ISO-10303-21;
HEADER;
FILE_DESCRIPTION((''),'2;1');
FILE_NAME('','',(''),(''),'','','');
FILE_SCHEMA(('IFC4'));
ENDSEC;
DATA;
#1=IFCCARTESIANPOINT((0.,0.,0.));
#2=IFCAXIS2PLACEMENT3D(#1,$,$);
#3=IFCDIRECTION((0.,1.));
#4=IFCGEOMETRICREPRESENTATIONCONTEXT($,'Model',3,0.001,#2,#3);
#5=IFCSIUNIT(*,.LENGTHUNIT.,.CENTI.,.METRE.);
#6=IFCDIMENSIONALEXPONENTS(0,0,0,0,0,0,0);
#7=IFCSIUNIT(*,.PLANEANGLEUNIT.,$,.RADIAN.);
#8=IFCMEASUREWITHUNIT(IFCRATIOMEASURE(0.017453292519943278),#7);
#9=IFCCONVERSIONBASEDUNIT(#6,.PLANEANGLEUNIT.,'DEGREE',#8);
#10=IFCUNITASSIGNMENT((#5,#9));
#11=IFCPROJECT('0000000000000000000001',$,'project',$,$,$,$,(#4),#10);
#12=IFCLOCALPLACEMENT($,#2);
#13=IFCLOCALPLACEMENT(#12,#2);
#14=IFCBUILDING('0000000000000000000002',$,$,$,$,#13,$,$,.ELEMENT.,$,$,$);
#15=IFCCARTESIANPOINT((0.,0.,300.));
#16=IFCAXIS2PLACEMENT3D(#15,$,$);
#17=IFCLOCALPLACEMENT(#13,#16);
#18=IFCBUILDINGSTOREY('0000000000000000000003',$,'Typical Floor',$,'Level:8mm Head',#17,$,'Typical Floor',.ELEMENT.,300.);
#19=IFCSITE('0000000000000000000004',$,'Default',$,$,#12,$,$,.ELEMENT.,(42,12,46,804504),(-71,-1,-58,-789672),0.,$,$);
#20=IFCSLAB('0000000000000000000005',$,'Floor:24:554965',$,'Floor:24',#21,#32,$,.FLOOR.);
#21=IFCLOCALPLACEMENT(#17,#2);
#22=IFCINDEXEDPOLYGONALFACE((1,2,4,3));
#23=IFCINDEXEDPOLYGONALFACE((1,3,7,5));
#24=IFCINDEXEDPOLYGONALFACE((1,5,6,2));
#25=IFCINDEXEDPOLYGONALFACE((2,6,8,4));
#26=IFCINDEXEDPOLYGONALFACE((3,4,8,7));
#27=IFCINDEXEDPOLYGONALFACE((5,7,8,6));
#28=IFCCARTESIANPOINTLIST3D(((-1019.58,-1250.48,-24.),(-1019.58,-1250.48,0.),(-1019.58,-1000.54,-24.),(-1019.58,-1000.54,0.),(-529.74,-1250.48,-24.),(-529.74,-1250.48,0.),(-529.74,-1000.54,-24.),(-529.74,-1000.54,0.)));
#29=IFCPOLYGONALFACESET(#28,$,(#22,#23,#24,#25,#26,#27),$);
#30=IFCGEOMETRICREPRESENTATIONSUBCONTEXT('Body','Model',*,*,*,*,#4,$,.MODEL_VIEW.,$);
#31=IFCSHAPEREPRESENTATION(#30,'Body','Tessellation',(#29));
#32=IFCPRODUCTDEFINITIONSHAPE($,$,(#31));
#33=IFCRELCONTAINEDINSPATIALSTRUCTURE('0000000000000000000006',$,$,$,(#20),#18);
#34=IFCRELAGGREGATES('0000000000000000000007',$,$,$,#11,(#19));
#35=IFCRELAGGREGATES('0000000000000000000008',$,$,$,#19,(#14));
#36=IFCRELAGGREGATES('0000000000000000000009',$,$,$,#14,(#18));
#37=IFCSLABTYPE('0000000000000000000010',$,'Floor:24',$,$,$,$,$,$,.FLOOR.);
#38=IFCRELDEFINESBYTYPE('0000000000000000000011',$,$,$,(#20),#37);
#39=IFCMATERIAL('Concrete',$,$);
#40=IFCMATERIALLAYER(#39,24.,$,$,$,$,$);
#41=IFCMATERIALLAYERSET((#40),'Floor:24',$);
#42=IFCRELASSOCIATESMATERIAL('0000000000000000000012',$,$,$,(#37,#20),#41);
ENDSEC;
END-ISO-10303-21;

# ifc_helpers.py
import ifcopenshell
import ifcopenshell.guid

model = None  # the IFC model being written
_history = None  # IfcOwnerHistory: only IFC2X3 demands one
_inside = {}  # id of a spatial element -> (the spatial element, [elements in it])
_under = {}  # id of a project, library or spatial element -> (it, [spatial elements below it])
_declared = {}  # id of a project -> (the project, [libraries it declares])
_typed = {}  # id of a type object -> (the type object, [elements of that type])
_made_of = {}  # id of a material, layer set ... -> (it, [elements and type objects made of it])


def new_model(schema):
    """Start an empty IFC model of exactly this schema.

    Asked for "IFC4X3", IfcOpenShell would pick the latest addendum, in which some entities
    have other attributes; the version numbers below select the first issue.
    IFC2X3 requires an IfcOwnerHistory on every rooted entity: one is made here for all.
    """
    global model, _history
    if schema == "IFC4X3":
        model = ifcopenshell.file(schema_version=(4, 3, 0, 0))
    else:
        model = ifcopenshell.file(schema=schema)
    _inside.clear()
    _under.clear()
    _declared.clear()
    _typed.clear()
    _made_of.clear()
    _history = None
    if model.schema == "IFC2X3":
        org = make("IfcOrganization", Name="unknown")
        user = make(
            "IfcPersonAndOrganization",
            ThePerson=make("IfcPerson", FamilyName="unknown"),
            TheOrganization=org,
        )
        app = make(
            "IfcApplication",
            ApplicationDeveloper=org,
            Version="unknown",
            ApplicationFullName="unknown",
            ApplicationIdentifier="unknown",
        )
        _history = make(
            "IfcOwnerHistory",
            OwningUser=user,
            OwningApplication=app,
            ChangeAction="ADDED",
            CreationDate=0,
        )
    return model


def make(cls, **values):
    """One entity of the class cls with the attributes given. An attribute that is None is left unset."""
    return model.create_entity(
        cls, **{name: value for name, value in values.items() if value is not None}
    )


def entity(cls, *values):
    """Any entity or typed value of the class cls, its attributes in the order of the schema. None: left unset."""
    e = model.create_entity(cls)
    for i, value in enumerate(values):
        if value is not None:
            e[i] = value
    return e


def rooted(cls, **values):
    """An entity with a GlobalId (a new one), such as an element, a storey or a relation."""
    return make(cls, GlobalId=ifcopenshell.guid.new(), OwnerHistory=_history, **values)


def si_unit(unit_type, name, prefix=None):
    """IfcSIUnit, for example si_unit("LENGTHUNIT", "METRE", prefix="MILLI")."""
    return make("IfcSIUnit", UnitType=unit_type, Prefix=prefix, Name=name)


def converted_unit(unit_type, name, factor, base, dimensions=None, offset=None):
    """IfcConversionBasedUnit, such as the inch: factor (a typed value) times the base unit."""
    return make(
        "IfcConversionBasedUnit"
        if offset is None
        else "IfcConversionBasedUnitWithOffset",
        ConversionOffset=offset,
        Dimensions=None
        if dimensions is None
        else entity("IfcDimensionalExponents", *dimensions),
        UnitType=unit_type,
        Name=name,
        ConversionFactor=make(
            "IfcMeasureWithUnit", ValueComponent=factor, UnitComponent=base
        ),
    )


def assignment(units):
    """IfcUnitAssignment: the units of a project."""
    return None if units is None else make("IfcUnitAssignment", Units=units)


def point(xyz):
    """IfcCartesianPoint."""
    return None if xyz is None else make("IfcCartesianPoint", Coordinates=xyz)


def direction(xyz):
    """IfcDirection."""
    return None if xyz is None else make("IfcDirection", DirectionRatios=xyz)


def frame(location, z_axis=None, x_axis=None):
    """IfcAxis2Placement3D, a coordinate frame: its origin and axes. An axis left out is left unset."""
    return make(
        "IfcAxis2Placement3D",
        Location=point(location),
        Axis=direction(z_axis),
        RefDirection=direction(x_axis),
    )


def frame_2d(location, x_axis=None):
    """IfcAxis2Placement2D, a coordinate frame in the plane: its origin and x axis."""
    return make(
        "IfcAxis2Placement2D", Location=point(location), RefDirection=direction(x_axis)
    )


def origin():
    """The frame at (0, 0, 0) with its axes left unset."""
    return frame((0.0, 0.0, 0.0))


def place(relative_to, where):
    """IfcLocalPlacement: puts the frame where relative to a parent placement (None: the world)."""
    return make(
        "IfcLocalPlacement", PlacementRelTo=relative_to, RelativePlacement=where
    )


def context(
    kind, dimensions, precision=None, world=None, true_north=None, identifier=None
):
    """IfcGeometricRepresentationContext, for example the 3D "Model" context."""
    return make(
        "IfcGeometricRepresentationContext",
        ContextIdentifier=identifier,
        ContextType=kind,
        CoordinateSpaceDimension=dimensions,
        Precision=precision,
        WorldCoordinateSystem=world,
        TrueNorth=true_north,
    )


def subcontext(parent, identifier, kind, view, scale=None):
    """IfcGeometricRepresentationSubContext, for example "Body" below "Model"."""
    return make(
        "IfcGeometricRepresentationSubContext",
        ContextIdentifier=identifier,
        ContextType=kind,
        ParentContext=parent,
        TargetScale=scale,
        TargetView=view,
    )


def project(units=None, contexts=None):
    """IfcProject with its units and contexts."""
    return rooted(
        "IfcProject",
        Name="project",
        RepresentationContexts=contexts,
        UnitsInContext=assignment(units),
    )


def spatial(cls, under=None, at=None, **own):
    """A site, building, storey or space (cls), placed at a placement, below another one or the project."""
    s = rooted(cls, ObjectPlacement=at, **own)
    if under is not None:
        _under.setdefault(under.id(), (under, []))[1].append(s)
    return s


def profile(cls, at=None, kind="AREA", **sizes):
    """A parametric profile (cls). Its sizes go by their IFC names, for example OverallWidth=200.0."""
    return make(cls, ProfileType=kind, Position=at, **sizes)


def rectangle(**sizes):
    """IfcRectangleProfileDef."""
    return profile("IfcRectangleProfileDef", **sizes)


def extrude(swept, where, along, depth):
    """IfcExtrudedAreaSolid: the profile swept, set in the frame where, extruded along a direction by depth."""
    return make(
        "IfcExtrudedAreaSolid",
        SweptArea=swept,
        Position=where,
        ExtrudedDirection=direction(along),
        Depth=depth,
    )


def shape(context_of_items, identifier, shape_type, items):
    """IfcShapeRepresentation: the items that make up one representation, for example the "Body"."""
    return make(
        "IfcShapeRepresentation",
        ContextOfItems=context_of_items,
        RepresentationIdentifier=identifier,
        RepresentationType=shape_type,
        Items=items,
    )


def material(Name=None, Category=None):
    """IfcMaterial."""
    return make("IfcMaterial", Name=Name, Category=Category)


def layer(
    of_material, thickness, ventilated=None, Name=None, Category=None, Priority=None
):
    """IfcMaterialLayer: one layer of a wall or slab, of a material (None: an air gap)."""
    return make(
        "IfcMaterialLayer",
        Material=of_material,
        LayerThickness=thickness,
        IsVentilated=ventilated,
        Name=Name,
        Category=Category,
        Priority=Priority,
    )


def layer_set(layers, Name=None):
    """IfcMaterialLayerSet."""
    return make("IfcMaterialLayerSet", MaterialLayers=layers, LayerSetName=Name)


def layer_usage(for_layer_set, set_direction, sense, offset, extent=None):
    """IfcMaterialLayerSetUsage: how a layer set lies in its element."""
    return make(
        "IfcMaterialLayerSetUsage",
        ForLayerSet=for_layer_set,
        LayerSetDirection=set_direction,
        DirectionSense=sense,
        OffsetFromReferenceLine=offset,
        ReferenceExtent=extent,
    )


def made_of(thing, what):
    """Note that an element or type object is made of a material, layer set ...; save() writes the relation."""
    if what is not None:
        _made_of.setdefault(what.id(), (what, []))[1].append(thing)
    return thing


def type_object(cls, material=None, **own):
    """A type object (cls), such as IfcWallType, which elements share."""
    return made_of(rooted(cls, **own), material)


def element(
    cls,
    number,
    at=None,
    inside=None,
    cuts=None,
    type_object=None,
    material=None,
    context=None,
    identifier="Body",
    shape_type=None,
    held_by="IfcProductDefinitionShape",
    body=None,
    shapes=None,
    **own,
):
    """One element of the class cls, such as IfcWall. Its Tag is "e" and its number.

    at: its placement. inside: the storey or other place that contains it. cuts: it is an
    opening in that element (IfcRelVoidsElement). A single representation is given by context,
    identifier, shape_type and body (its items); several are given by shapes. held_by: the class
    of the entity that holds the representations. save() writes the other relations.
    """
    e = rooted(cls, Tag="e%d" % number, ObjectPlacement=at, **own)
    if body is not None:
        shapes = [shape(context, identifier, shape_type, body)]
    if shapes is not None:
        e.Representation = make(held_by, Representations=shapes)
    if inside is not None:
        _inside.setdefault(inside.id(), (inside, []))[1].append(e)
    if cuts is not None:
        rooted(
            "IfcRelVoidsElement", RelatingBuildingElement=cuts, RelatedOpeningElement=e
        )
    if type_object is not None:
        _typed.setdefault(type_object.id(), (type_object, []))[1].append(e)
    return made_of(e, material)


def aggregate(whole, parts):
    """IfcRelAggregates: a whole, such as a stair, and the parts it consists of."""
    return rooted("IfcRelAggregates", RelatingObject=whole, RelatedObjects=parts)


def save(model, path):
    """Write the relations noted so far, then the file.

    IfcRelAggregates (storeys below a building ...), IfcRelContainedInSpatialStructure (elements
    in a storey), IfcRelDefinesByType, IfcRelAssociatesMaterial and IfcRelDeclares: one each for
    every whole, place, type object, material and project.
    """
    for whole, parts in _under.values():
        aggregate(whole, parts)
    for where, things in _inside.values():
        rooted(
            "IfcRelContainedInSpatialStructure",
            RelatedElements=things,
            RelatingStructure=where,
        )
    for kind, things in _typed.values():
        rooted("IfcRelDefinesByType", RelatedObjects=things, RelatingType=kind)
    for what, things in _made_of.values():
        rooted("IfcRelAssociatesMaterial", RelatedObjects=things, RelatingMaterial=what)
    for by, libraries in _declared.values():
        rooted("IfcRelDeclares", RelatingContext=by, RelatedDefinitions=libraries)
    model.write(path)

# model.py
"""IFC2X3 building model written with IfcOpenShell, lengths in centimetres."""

from ifc_helpers import new_model, entity, si_unit, converted_unit, direction, frame, frame_2d, origin, place, context, subcontext, project, spatial, rectangle, extrude, material, layer, layer_set, layer_usage, type_object, element, save


model = new_model("IFC2X3")

# Units and contexts
model_context = context("Model", 3, precision=0.001, world=origin(), true_north=direction((0.0, 1.0)))
body_context = subcontext(model_context, "Body", "Model", "MODEL_VIEW")
ifc_project = project(units=[si_unit("LENGTHUNIT", "METRE", prefix="CENTI"), converted_unit("PLANEANGLEUNIT", "DEGREE", entity("IfcRatioMeasure", 0.017453292519943278), si_unit("PLANEANGLEUNIT", "RADIAN"), dimensions=[0, 0, 0, 0, 0, 0, 0])], contexts=[model_context])

# Site, building, storey
site_placement = place(None, origin())
site = spatial("IfcSite", under=ifc_project, at=site_placement, Name="Default", CompositionType="ELEMENT", RefLatitude=(42, 12, 46, 804504), RefLongitude=(-71, -1, -58, -789672), RefElevation=0.0)
building_placement = place(site_placement, origin())
building = spatial("IfcBuilding", under=site, at=building_placement, CompositionType="ELEMENT")
storey_placement = place(building_placement, frame((0.0, 0.0, 300.0)))
storey = spatial("IfcBuildingStorey", under=building, at=storey_placement, Name="Typical Floor", ObjectType="Level:8mm Head", LongName="Typical Floor", CompositionType="ELEMENT", Elevation=300.0)

# Shared definitions
ifc_material = material(Name="Concrete")

# Slab
ifc_layer = layer(ifc_material, 24.0)
ifc_layer_set = layer_set([ifc_layer], Name="Floor:24")
ifc_layer_usage_1 = layer_usage(ifc_layer_set, "AXIS3", "POSITIVE", 0.0)
slab_type_1 = type_object("IfcSlabType", Name="Floor:24", PredefinedType="FLOOR", material=ifc_layer_set)
slab_1_placement = place(storey_placement, origin())
element("IfcSlab", 1, at=slab_1_placement, inside=storey, type_object=slab_type_1, material=ifc_layer_usage_1, Name="Floor:24:554965", ObjectType="Floor:24", PredefinedType="FLOOR", context=body_context, shape_type="SweptSolid", body=[
    extrude(rectangle(XDim=249.95, YDim=489.84, at=frame_2d((0.0, 0.0), x_axis=(1.0, 0.0))), frame((-774.66, -1125.51, 0.0), z_axis=(0.0, 0.0, -1.0), x_axis=(0.0, 1.0, 0.0)), (0.0, 0.0, 1.0), 24.0),
])

save(model, "model.ifc")
